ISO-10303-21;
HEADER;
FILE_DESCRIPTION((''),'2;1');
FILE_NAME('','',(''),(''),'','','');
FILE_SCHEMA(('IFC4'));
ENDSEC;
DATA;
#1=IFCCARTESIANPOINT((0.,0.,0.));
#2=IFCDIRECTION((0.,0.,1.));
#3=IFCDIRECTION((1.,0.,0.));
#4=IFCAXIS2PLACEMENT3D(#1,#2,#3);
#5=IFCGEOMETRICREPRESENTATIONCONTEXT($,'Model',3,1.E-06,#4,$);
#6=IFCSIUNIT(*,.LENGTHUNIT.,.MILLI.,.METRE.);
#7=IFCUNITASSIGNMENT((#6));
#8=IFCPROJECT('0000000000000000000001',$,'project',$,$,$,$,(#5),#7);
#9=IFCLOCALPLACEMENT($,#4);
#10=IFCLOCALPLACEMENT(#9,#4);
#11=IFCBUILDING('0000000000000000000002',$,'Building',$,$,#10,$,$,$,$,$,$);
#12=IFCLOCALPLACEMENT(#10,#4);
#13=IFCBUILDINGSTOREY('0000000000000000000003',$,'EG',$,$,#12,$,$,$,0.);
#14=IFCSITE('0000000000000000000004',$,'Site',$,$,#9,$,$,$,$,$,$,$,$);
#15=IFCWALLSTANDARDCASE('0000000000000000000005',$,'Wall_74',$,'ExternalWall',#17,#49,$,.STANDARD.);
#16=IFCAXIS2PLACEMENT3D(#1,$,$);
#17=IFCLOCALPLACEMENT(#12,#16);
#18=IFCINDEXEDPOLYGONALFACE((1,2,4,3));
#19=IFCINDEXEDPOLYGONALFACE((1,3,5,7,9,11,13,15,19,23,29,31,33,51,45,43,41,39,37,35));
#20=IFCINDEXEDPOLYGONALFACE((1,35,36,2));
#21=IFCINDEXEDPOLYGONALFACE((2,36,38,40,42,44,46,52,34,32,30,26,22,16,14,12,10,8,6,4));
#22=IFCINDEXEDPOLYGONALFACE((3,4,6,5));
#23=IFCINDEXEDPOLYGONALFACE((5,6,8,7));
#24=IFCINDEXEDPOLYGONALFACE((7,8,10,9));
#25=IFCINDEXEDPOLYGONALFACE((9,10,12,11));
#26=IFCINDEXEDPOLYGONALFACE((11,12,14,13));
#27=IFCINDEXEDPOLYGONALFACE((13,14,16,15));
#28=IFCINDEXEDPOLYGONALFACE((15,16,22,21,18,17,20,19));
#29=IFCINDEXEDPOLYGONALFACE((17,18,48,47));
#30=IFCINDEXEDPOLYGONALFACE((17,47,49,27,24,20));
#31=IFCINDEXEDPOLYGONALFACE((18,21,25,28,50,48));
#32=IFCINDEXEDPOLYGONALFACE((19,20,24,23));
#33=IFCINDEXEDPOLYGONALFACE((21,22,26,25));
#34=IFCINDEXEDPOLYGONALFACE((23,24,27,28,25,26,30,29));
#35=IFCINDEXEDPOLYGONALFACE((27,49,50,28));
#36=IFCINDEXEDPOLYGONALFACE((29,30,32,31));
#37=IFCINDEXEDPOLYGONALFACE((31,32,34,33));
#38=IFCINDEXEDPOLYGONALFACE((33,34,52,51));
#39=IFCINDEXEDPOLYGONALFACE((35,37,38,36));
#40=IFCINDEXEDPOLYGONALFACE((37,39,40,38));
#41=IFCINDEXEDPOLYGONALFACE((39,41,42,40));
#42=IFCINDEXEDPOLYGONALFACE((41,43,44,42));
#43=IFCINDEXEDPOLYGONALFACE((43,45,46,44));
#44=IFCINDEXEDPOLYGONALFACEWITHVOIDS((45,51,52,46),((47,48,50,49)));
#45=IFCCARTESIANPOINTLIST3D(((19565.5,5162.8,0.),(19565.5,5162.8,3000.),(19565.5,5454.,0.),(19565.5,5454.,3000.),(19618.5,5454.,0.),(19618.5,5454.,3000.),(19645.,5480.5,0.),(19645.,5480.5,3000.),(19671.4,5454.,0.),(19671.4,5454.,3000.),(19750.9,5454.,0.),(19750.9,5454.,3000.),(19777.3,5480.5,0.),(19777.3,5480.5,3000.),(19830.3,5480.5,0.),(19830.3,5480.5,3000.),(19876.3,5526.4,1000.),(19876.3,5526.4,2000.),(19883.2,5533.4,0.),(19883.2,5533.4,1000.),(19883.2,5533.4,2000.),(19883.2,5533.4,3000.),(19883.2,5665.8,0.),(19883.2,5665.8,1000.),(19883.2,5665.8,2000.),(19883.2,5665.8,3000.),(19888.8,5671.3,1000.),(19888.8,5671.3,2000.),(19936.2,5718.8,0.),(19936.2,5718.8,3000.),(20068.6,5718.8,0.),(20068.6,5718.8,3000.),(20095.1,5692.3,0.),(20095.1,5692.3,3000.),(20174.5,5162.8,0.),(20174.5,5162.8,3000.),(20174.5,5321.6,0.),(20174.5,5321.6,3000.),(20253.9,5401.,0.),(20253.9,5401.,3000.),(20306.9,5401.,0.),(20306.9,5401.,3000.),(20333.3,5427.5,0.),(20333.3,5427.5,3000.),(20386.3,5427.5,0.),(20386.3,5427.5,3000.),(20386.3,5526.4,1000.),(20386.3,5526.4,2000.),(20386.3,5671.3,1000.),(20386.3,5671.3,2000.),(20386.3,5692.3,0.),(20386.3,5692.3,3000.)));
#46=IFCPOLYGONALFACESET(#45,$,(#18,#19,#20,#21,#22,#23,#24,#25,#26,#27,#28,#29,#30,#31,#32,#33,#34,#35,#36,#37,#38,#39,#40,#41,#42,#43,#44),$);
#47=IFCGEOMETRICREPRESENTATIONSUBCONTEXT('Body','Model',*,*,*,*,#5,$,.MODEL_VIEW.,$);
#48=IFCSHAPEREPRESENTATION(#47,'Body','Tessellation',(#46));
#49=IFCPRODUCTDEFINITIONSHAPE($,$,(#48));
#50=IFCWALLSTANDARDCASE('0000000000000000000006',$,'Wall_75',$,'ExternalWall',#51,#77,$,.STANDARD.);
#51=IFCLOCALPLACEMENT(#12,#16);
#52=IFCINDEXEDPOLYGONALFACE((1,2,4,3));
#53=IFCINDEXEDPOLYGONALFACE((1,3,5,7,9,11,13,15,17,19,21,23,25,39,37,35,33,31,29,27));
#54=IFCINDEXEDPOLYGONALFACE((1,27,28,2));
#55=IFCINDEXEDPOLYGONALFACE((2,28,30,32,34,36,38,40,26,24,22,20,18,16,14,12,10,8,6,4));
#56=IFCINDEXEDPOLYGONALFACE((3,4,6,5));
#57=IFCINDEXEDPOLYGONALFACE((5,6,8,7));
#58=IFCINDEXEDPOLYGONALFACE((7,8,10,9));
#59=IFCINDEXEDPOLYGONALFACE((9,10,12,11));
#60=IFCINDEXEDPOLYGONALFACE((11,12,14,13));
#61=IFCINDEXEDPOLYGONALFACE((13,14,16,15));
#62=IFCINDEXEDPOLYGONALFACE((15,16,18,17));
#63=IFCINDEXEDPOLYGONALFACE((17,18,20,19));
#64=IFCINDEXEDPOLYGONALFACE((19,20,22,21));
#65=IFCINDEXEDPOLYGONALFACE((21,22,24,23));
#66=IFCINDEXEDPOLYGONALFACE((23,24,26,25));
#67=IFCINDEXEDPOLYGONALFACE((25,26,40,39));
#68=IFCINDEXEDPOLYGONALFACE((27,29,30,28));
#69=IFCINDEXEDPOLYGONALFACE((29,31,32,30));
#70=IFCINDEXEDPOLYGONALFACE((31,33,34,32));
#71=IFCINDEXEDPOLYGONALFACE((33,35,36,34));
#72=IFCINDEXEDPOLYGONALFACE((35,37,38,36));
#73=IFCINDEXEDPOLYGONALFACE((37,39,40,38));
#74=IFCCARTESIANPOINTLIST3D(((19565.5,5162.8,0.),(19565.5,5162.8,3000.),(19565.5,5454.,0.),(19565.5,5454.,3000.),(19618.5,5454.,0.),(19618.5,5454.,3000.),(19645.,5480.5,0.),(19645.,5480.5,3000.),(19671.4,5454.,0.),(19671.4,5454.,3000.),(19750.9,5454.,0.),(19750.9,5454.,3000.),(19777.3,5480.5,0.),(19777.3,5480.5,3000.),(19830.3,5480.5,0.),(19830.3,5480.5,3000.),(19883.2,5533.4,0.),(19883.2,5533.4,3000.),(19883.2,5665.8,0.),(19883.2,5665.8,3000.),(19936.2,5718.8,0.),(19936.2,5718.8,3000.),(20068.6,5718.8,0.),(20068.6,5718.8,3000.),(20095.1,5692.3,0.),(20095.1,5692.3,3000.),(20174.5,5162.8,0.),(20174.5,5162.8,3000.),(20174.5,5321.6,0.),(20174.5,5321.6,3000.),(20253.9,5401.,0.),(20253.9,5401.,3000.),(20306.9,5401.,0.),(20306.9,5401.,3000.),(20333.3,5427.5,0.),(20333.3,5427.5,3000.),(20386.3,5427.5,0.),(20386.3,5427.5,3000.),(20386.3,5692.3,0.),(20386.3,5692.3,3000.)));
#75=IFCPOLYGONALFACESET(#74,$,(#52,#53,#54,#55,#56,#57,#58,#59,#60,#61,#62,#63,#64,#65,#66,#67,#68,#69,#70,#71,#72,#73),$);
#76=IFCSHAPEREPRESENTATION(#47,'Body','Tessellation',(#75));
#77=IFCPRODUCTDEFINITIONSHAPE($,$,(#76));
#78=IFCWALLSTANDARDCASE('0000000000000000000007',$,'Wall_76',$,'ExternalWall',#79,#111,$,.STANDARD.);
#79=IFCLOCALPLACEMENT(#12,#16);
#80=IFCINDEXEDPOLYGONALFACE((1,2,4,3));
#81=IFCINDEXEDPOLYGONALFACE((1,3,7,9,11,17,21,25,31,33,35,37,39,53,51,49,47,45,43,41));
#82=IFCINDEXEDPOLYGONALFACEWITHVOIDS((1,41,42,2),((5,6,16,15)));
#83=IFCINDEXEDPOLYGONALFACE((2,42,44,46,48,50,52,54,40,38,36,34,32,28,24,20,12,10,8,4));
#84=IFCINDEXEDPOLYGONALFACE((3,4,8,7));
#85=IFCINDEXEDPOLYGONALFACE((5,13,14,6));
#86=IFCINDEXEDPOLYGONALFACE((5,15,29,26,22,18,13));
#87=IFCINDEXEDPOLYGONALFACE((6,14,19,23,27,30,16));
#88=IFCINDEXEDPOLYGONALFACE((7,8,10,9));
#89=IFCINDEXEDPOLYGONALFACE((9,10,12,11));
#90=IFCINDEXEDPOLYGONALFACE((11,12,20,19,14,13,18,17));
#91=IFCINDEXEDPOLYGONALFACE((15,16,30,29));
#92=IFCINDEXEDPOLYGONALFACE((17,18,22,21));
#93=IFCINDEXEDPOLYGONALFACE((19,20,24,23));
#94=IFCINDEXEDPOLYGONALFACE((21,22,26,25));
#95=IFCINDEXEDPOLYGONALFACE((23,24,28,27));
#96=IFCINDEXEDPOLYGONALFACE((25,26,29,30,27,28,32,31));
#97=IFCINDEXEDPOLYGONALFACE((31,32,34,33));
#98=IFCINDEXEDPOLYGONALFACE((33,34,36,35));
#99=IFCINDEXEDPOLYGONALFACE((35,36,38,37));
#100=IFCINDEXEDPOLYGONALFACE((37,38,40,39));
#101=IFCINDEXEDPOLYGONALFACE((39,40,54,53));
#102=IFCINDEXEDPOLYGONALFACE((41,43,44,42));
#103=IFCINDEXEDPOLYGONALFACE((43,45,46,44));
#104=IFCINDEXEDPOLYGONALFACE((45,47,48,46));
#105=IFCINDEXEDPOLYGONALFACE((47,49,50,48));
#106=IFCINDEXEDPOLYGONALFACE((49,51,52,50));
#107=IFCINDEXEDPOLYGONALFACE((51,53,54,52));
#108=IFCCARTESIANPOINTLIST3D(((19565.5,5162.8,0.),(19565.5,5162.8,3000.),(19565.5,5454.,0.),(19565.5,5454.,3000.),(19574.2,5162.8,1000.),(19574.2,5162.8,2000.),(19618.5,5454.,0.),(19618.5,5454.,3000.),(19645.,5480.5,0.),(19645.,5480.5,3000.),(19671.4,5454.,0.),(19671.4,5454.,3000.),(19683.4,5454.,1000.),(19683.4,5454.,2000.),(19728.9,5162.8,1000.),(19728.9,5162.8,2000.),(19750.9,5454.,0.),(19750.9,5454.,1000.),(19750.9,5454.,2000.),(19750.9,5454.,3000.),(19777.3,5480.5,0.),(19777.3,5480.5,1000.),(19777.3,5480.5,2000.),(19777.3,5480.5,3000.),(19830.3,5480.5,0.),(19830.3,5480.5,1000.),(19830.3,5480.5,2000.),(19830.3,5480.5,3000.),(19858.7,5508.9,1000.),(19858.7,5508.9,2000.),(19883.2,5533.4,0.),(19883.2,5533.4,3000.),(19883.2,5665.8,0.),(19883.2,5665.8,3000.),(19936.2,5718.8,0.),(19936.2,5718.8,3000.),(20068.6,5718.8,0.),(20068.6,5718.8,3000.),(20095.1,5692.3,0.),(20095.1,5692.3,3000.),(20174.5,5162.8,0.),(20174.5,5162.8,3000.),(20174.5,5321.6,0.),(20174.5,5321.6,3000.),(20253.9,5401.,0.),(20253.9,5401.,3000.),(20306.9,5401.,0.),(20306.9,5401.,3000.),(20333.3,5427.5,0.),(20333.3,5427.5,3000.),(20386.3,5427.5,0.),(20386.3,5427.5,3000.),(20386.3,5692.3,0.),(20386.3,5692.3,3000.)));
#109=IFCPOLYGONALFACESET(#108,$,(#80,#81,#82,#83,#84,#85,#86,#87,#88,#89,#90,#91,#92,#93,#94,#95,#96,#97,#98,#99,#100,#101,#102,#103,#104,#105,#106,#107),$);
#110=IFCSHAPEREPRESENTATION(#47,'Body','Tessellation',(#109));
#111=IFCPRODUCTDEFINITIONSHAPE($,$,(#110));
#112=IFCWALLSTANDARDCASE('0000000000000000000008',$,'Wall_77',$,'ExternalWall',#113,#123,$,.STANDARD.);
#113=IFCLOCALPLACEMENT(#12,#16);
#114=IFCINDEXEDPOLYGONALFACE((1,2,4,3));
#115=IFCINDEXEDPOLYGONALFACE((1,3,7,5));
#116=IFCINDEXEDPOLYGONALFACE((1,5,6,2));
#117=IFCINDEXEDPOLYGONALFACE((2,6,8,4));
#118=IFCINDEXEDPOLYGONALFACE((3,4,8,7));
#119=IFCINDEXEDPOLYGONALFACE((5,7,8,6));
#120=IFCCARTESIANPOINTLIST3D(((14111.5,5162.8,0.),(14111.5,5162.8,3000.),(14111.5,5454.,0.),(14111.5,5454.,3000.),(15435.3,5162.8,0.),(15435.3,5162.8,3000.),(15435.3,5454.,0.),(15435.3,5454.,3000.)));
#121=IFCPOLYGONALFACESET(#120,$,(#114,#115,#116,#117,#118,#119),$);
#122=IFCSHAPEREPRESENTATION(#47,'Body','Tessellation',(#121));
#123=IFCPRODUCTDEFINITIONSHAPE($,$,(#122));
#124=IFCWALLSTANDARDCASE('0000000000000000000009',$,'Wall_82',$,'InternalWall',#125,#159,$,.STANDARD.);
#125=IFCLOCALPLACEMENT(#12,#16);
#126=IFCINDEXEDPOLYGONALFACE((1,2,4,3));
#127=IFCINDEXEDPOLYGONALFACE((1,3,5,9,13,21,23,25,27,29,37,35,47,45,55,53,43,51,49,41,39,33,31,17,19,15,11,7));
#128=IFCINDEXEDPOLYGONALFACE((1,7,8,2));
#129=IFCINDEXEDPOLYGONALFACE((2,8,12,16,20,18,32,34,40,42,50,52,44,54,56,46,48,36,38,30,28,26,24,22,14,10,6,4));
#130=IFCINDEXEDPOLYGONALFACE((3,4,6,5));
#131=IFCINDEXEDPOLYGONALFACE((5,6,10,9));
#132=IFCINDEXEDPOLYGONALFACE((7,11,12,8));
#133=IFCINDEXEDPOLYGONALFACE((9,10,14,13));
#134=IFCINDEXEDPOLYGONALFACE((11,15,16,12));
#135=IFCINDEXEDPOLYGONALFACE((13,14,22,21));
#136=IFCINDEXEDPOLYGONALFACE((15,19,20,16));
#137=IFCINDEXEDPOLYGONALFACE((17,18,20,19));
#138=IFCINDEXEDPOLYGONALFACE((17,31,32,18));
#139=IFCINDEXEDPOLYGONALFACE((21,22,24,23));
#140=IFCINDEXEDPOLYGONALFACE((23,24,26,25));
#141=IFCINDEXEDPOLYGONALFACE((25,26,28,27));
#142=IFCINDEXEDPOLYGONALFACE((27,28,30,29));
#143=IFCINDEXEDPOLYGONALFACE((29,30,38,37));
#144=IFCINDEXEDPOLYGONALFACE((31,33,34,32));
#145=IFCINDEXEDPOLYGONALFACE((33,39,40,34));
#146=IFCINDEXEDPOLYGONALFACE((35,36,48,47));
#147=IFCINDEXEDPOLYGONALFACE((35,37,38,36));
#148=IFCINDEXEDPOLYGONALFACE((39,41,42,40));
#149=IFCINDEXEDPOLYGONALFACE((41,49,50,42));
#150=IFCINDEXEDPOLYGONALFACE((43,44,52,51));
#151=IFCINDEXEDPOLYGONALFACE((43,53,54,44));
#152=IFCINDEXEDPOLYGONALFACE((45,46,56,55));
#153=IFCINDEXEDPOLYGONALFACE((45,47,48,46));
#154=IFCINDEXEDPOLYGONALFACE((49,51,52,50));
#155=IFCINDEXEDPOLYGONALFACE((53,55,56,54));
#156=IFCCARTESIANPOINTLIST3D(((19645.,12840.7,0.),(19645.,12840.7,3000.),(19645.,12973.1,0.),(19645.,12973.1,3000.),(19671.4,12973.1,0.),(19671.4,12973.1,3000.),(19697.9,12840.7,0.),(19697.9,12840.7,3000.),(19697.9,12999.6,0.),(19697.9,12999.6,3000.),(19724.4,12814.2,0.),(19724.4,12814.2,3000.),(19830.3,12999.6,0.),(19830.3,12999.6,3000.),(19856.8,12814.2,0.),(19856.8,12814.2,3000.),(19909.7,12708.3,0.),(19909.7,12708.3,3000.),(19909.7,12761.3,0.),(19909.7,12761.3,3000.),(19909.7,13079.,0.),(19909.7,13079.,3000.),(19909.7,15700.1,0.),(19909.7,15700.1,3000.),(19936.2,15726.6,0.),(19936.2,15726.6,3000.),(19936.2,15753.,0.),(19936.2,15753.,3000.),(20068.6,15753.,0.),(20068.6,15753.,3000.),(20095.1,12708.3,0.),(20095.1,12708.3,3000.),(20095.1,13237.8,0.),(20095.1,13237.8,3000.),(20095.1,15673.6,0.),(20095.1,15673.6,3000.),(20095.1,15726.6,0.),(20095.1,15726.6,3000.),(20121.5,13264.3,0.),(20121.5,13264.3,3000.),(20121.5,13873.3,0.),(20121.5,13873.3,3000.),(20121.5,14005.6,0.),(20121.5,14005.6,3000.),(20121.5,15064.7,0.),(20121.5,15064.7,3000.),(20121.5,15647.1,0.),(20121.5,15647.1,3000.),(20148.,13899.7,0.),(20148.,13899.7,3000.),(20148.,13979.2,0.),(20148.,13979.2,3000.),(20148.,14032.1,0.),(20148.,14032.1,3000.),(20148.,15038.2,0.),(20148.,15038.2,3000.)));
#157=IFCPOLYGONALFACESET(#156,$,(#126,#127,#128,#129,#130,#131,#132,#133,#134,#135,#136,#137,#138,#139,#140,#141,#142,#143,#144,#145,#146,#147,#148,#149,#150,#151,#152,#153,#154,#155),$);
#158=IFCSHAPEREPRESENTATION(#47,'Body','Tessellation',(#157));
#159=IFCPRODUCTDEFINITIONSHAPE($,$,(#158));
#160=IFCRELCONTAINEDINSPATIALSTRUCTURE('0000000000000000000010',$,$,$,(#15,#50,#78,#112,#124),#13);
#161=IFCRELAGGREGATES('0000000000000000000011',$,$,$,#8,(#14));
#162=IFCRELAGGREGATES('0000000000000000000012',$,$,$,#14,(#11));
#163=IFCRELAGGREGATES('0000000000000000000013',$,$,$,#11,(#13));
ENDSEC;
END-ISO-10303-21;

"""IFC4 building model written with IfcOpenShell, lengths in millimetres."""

from ifc_helpers import new_model, si_unit, frame, origin_with_axes, place, context, subcontext, project, spatial, polyline, rectangle, outline, extrude, element, save


model = new_model("IFC4")

# Units and contexts
model_context = context("Model", 3, precision=1e-06, world=origin_with_axes())
body_context = subcontext(model_context, "Body", "Model", "MODEL_VIEW")
ifc_project = project(units=[si_unit("LENGTHUNIT", "METRE", prefix="MILLI")], contexts=[model_context])

# Site, building, storey
site_placement = place(None, origin_with_axes())
site = spatial("IfcSite", under=ifc_project, at=site_placement, Name="Site")
building_placement = place(site_placement, origin_with_axes())
building = spatial("IfcBuilding", under=site, at=building_placement, Name="Building")
storey_placement = place(building_placement, origin_with_axes())
storey = spatial("IfcBuildingStorey", under=building, at=storey_placement, Name="EG", Elevation=0.0)

# Wall, opening
wall_1_placement = place(storey_placement, origin_with_axes())
wall_1 = element("IfcWallStandardCase", 1, at=wall_1_placement, inside=storey, Name="Wall_74", ObjectType="ExternalWall", PredefinedType="STANDARD", context=body_context, shape_type="SweptSolid", body=[
    extrude(outline(polyline([(19565.5, 5162.8, 0.0), (19565.5, 5454.0, 0.0), (19618.5, 5454.0, 0.0), (19645.0, 5480.5, 0.0), (19671.4, 5454.0, 0.0), (19750.9, 5454.0, 0.0), (19777.3, 5480.5, 0.0), (19830.3, 5480.5, 0.0), (19883.2, 5533.4, 0.0), (19883.2, 5665.8, 0.0), (19936.2, 5718.8, 0.0), (20068.6, 5718.8, 0.0), (20095.1, 5692.3, 0.0), (20386.3, 5692.3, 0.0), (20386.3, 5427.5, 0.0), (20333.3, 5427.5, 0.0), (20306.9, 5401.0, 0.0), (20253.9, 5401.0, 0.0), (20174.5, 5321.6, 0.0), (20174.5, 5162.8, 0.0), (19565.5, 5162.8, 0.0)])), origin_with_axes(), (0.0, 0.0, 1.0), 3000.0),
])
opening_1_placement = place(wall_1_placement, origin_with_axes())
element("IfcOpeningElement", 2, at=opening_1_placement, inside=storey, cuts=wall_1, context=body_context, shape_type="SweptSolid", body=[
    extrude(rectangle(XDim=2956.0, YDim=144.9), frame((20251.7, 5598.9, 1000.0), z_axis=(0.0, 0.0, 1.0), x_axis=(1.0, 0.0, 0.0)), (0.0, 0.0, 1.0), 1000.0),
])

# Wall
wall_2_placement = place(storey_placement, origin_with_axes())
element("IfcWallStandardCase", 3, at=wall_2_placement, inside=storey, Name="Wall_75", ObjectType="ExternalWall", PredefinedType="STANDARD", context=body_context, shape_type="SweptSolid", body=[
    extrude(outline(polyline([(19565.5, 5162.8, 0.0), (19565.5, 5454.0, 0.0), (19618.5, 5454.0, 0.0), (19645.0, 5480.5, 0.0), (19671.4, 5454.0, 0.0), (19750.9, 5454.0, 0.0), (19777.3, 5480.5, 0.0), (19830.3, 5480.5, 0.0), (19883.2, 5533.4, 0.0), (19883.2, 5665.8, 0.0), (19936.2, 5718.8, 0.0), (20068.6, 5718.8, 0.0), (20095.1, 5692.3, 0.0), (20386.3, 5692.3, 0.0), (20386.3, 5427.5, 0.0), (20333.3, 5427.5, 0.0), (20306.9, 5401.0, 0.0), (20253.9, 5401.0, 0.0), (20174.5, 5321.6, 0.0), (20174.5, 5162.8, 0.0), (19565.5, 5162.8, 0.0)])), origin_with_axes(), (0.0, 0.0, 1.0), 3000.0),
])

# Wall, opening
wall_3_placement = place(storey_placement, origin_with_axes())
wall_3 = element("IfcWallStandardCase", 4, at=wall_3_placement, inside=storey, Name="Wall_76", ObjectType="ExternalWall", PredefinedType="STANDARD", context=body_context, shape_type="SweptSolid", body=[
    extrude(outline(polyline([(19565.5, 5162.8, 0.0), (19565.5, 5454.0, 0.0), (19618.5, 5454.0, 0.0), (19645.0, 5480.5, 0.0), (19671.4, 5454.0, 0.0), (19750.9, 5454.0, 0.0), (19777.3, 5480.5, 0.0), (19830.3, 5480.5, 0.0), (19883.2, 5533.4, 0.0), (19883.2, 5665.8, 0.0), (19936.2, 5718.8, 0.0), (20068.6, 5718.8, 0.0), (20095.1, 5692.3, 0.0), (20386.3, 5692.3, 0.0), (20386.3, 5427.5, 0.0), (20333.3, 5427.5, 0.0), (20306.9, 5401.0, 0.0), (20253.9, 5401.0, 0.0), (20174.5, 5321.6, 0.0), (20174.5, 5162.8, 0.0), (19565.5, 5162.8, 0.0)])), origin_with_axes(), (0.0, 0.0, 1.0), 3000.0),
])
opening_2_placement = place(wall_3_placement, origin_with_axes())
element("IfcOpeningElement", 5, at=opening_2_placement, inside=storey, cuts=wall_3, context=body_context, shape_type="SweptSolid", body=[
    extrude(rectangle(XDim=694.1, YDim=144.9), frame((19685.1, 5252.3, 1000.0), z_axis=(0.0, 0.0, 1.0), x_axis=(0.351123, 0.936329, 0.0)), (0.0, 0.0, 1.0), 1000.0),
])

# Walls
for number, where, z_axis, x_axis, name in (
    (6, (0.0, 0.0, 0.0), (0.0, 0.0, 1.0), (1.0, 0.0, 0.0), "Wall_77"),
):
    element("IfcWallStandardCase", number, at=place(storey_placement, frame(where, z_axis=z_axis, x_axis=x_axis)), inside=storey, Name=name, ObjectType="ExternalWall", PredefinedType="STANDARD", context=body_context, shape_type="SweptSolid", body=[
        extrude(outline(polyline([(14111.5, 5162.8, 0.0), (14111.5, 5454.0, 0.0), (15435.3, 5454.0, 0.0), (15435.3, 5162.8, 0.0), (14111.5, 5162.8, 0.0)])), origin_with_axes(), (0.0, 0.0, 1.0), 3000.0),
    ])
wall_4_placement = place(storey_placement, origin_with_axes())
element("IfcWallStandardCase", 7, at=wall_4_placement, inside=storey, Name="Wall_82", ObjectType="InternalWall", PredefinedType="STANDARD", context=body_context, shape_type="SweptSolid", body=[
    extrude(outline(polyline([(19909.7, 12708.3, 0.0), (19909.7, 12761.3, 0.0), (19856.8, 12814.2, 0.0), (19724.4, 12814.2, 0.0), (19697.9, 12840.7, 0.0), (19645.0, 12840.7, 0.0), (19645.0, 12973.1, 0.0), (19671.4, 12973.1, 0.0), (19697.9, 12999.6, 0.0), (19830.3, 12999.6, 0.0), (19909.7, 13079.0, 0.0), (19909.7, 15700.1, 0.0), (19936.2, 15726.6, 0.0), (19936.2, 15753.0, 0.0), (20068.6, 15753.0, 0.0), (20095.1, 15726.6, 0.0), (20095.1, 15673.6, 0.0), (20121.5, 15647.1, 0.0), (20121.5, 15064.7, 0.0), (20148.0, 15038.2, 0.0), (20148.0, 14032.1, 0.0), (20121.5, 14005.6, 0.0), (20148.0, 13979.2, 0.0), (20148.0, 13899.7, 0.0), (20121.5, 13873.3, 0.0), (20121.5, 13264.3, 0.0), (20095.1, 13237.8, 0.0), (20095.1, 12708.3, 0.0), (19909.7, 12708.3, 0.0)])), origin_with_axes(), (0.0, 0.0, 1.0), 3000.0),
])

save(model, "model.ifc")
